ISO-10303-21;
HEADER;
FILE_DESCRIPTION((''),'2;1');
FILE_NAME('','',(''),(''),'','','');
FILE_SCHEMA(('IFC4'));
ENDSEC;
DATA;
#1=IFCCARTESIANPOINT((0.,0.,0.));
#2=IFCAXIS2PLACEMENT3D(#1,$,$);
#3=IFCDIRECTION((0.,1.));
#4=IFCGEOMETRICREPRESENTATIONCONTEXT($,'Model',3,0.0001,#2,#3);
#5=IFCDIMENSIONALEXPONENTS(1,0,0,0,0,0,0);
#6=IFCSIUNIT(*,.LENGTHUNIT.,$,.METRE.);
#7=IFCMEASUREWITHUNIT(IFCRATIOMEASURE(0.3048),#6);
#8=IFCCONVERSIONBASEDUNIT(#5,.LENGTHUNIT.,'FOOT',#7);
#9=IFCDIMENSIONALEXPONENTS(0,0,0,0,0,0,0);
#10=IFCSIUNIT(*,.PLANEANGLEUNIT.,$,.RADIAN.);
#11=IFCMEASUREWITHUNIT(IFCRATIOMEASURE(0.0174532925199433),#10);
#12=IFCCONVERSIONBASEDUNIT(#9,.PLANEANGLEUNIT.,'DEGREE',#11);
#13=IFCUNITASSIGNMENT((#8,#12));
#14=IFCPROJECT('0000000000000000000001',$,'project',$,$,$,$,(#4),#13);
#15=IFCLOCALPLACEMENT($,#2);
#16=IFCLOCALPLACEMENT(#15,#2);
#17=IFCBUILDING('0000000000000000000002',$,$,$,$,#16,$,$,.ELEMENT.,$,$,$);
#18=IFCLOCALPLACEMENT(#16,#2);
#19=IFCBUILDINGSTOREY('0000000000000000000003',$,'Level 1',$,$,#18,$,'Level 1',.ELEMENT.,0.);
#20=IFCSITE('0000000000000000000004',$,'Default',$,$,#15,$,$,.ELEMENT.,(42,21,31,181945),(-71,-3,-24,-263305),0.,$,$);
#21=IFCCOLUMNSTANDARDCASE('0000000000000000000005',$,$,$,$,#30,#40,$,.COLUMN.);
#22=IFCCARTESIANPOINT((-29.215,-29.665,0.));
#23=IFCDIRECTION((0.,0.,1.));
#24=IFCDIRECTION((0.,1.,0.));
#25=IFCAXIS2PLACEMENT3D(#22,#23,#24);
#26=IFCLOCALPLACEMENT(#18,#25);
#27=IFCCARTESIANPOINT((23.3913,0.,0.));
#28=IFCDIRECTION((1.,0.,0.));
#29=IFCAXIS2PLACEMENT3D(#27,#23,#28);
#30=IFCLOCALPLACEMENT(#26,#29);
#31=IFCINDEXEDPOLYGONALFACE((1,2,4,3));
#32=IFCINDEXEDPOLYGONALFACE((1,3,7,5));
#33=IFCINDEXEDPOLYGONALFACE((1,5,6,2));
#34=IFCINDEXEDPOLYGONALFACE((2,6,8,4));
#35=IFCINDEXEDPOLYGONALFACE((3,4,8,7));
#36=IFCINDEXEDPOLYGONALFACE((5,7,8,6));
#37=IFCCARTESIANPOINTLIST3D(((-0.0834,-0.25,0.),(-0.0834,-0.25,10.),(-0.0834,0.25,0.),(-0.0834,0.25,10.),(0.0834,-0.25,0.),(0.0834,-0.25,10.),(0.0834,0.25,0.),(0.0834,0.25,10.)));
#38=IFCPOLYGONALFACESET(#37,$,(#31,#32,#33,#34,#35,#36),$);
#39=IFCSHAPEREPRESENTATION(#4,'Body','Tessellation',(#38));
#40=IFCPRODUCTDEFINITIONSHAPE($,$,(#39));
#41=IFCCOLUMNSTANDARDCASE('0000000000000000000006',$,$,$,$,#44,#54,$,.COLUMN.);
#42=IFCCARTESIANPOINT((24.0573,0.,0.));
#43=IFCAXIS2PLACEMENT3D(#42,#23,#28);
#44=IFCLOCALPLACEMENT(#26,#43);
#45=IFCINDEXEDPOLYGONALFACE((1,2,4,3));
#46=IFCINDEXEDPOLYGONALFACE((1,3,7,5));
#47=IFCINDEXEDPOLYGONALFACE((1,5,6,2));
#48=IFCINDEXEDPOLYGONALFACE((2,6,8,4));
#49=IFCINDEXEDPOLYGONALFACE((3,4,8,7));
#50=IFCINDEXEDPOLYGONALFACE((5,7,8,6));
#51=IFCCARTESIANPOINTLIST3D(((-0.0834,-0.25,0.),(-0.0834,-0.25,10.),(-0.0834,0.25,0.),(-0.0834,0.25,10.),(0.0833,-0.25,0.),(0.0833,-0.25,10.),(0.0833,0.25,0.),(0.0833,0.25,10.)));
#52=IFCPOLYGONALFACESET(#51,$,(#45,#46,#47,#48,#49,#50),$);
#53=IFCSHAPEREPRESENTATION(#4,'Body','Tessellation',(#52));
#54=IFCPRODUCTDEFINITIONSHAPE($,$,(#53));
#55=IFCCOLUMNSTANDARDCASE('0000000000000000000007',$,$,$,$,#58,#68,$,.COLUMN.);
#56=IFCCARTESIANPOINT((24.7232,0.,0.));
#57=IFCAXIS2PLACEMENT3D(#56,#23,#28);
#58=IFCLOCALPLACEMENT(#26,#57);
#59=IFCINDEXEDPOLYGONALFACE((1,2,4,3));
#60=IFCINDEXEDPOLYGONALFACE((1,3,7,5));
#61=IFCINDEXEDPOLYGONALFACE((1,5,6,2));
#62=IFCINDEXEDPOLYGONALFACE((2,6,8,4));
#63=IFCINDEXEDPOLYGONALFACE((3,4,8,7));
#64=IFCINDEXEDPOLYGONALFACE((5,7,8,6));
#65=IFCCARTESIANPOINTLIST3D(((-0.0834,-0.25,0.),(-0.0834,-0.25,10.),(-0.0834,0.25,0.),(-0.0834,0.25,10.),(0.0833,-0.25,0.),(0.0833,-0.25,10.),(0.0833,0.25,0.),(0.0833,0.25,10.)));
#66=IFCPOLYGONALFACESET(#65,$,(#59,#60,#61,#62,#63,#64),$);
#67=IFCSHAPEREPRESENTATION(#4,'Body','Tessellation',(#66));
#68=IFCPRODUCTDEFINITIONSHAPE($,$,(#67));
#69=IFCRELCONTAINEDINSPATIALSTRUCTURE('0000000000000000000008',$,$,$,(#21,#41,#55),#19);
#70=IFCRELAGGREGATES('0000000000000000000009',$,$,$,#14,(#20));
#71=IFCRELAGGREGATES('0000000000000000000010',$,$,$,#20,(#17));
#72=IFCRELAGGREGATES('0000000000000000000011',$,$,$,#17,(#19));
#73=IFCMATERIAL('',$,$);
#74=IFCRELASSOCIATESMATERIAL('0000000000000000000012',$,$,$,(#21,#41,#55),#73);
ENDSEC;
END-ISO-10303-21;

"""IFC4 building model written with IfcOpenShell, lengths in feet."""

from ifc_helpers import new_model, entity, si_unit, converted_unit, direction, frame, origin, place, context, project, spatial, rectangle, extrude, material, element, save


model = new_model("IFC4")

# Units and contexts
model_context = context("Model", 3, precision=0.0001, world=origin(), true_north=direction((0.0, 1.0)))
ifc_project = project(units=[converted_unit("LENGTHUNIT", "FOOT", entity("IfcRatioMeasure", 0.3048), si_unit("LENGTHUNIT", "METRE"), dimensions=[1, 0, 0, 0, 0, 0, 0]), converted_unit("PLANEANGLEUNIT", "DEGREE", entity("IfcRatioMeasure", 0.0174532925199433), si_unit("PLANEANGLEUNIT", "RADIAN"), dimensions=[0, 0, 0, 0, 0, 0, 0])], contexts=[model_context])

# Site, building, storey
site_placement = place(None, origin())
site = spatial("IfcSite", under=ifc_project, at=site_placement, Name="Default", CompositionType="ELEMENT", RefLatitude=(42, 21, 31, 181945), RefLongitude=(-71, -3, -24, -263305), RefElevation=0.0)
building_placement = place(site_placement, origin())
building = spatial("IfcBuilding", under=site, at=building_placement, CompositionType="ELEMENT")
storey_placement = place(building_placement, origin())
storey = spatial("IfcBuildingStorey", under=building, at=storey_placement, Name="Level 1", LongName="Level 1", CompositionType="ELEMENT", Elevation=0.0)

# Columns
ifc_material = material(Name="")
placement = place(storey_placement, frame((-29.215, -29.665, 0.0), z_axis=(0.0, 0.0, 1.0), x_axis=(0.0, 1.0, 0.0)))
for number, where, z_axis, x_axis in (
    (1, (23.3913, 0.0, 0.0), (0.0, 0.0, 1.0), (1.0, 0.0, 0.0)),
    (2, (24.0573, 0.0, 0.0), (0.0, 0.0, 1.0), (1.0, 0.0, 0.0)),
    (3, (24.7232, 0.0, 0.0), (0.0, 0.0, 1.0), (1.0, 0.0, 0.0)),
):
    element("IfcColumnStandardCase", number, at=place(placement, frame(where, z_axis=z_axis, x_axis=x_axis)), inside=storey, material=ifc_material, PredefinedType="COLUMN", context=model_context, shape_type="SweptSolid", body=[
        extrude(rectangle(XDim=0.1667, YDim=0.5), origin(), (0.0, 0.0, 1.0), 10.0),
    ])

save(model, "model.ifc")
